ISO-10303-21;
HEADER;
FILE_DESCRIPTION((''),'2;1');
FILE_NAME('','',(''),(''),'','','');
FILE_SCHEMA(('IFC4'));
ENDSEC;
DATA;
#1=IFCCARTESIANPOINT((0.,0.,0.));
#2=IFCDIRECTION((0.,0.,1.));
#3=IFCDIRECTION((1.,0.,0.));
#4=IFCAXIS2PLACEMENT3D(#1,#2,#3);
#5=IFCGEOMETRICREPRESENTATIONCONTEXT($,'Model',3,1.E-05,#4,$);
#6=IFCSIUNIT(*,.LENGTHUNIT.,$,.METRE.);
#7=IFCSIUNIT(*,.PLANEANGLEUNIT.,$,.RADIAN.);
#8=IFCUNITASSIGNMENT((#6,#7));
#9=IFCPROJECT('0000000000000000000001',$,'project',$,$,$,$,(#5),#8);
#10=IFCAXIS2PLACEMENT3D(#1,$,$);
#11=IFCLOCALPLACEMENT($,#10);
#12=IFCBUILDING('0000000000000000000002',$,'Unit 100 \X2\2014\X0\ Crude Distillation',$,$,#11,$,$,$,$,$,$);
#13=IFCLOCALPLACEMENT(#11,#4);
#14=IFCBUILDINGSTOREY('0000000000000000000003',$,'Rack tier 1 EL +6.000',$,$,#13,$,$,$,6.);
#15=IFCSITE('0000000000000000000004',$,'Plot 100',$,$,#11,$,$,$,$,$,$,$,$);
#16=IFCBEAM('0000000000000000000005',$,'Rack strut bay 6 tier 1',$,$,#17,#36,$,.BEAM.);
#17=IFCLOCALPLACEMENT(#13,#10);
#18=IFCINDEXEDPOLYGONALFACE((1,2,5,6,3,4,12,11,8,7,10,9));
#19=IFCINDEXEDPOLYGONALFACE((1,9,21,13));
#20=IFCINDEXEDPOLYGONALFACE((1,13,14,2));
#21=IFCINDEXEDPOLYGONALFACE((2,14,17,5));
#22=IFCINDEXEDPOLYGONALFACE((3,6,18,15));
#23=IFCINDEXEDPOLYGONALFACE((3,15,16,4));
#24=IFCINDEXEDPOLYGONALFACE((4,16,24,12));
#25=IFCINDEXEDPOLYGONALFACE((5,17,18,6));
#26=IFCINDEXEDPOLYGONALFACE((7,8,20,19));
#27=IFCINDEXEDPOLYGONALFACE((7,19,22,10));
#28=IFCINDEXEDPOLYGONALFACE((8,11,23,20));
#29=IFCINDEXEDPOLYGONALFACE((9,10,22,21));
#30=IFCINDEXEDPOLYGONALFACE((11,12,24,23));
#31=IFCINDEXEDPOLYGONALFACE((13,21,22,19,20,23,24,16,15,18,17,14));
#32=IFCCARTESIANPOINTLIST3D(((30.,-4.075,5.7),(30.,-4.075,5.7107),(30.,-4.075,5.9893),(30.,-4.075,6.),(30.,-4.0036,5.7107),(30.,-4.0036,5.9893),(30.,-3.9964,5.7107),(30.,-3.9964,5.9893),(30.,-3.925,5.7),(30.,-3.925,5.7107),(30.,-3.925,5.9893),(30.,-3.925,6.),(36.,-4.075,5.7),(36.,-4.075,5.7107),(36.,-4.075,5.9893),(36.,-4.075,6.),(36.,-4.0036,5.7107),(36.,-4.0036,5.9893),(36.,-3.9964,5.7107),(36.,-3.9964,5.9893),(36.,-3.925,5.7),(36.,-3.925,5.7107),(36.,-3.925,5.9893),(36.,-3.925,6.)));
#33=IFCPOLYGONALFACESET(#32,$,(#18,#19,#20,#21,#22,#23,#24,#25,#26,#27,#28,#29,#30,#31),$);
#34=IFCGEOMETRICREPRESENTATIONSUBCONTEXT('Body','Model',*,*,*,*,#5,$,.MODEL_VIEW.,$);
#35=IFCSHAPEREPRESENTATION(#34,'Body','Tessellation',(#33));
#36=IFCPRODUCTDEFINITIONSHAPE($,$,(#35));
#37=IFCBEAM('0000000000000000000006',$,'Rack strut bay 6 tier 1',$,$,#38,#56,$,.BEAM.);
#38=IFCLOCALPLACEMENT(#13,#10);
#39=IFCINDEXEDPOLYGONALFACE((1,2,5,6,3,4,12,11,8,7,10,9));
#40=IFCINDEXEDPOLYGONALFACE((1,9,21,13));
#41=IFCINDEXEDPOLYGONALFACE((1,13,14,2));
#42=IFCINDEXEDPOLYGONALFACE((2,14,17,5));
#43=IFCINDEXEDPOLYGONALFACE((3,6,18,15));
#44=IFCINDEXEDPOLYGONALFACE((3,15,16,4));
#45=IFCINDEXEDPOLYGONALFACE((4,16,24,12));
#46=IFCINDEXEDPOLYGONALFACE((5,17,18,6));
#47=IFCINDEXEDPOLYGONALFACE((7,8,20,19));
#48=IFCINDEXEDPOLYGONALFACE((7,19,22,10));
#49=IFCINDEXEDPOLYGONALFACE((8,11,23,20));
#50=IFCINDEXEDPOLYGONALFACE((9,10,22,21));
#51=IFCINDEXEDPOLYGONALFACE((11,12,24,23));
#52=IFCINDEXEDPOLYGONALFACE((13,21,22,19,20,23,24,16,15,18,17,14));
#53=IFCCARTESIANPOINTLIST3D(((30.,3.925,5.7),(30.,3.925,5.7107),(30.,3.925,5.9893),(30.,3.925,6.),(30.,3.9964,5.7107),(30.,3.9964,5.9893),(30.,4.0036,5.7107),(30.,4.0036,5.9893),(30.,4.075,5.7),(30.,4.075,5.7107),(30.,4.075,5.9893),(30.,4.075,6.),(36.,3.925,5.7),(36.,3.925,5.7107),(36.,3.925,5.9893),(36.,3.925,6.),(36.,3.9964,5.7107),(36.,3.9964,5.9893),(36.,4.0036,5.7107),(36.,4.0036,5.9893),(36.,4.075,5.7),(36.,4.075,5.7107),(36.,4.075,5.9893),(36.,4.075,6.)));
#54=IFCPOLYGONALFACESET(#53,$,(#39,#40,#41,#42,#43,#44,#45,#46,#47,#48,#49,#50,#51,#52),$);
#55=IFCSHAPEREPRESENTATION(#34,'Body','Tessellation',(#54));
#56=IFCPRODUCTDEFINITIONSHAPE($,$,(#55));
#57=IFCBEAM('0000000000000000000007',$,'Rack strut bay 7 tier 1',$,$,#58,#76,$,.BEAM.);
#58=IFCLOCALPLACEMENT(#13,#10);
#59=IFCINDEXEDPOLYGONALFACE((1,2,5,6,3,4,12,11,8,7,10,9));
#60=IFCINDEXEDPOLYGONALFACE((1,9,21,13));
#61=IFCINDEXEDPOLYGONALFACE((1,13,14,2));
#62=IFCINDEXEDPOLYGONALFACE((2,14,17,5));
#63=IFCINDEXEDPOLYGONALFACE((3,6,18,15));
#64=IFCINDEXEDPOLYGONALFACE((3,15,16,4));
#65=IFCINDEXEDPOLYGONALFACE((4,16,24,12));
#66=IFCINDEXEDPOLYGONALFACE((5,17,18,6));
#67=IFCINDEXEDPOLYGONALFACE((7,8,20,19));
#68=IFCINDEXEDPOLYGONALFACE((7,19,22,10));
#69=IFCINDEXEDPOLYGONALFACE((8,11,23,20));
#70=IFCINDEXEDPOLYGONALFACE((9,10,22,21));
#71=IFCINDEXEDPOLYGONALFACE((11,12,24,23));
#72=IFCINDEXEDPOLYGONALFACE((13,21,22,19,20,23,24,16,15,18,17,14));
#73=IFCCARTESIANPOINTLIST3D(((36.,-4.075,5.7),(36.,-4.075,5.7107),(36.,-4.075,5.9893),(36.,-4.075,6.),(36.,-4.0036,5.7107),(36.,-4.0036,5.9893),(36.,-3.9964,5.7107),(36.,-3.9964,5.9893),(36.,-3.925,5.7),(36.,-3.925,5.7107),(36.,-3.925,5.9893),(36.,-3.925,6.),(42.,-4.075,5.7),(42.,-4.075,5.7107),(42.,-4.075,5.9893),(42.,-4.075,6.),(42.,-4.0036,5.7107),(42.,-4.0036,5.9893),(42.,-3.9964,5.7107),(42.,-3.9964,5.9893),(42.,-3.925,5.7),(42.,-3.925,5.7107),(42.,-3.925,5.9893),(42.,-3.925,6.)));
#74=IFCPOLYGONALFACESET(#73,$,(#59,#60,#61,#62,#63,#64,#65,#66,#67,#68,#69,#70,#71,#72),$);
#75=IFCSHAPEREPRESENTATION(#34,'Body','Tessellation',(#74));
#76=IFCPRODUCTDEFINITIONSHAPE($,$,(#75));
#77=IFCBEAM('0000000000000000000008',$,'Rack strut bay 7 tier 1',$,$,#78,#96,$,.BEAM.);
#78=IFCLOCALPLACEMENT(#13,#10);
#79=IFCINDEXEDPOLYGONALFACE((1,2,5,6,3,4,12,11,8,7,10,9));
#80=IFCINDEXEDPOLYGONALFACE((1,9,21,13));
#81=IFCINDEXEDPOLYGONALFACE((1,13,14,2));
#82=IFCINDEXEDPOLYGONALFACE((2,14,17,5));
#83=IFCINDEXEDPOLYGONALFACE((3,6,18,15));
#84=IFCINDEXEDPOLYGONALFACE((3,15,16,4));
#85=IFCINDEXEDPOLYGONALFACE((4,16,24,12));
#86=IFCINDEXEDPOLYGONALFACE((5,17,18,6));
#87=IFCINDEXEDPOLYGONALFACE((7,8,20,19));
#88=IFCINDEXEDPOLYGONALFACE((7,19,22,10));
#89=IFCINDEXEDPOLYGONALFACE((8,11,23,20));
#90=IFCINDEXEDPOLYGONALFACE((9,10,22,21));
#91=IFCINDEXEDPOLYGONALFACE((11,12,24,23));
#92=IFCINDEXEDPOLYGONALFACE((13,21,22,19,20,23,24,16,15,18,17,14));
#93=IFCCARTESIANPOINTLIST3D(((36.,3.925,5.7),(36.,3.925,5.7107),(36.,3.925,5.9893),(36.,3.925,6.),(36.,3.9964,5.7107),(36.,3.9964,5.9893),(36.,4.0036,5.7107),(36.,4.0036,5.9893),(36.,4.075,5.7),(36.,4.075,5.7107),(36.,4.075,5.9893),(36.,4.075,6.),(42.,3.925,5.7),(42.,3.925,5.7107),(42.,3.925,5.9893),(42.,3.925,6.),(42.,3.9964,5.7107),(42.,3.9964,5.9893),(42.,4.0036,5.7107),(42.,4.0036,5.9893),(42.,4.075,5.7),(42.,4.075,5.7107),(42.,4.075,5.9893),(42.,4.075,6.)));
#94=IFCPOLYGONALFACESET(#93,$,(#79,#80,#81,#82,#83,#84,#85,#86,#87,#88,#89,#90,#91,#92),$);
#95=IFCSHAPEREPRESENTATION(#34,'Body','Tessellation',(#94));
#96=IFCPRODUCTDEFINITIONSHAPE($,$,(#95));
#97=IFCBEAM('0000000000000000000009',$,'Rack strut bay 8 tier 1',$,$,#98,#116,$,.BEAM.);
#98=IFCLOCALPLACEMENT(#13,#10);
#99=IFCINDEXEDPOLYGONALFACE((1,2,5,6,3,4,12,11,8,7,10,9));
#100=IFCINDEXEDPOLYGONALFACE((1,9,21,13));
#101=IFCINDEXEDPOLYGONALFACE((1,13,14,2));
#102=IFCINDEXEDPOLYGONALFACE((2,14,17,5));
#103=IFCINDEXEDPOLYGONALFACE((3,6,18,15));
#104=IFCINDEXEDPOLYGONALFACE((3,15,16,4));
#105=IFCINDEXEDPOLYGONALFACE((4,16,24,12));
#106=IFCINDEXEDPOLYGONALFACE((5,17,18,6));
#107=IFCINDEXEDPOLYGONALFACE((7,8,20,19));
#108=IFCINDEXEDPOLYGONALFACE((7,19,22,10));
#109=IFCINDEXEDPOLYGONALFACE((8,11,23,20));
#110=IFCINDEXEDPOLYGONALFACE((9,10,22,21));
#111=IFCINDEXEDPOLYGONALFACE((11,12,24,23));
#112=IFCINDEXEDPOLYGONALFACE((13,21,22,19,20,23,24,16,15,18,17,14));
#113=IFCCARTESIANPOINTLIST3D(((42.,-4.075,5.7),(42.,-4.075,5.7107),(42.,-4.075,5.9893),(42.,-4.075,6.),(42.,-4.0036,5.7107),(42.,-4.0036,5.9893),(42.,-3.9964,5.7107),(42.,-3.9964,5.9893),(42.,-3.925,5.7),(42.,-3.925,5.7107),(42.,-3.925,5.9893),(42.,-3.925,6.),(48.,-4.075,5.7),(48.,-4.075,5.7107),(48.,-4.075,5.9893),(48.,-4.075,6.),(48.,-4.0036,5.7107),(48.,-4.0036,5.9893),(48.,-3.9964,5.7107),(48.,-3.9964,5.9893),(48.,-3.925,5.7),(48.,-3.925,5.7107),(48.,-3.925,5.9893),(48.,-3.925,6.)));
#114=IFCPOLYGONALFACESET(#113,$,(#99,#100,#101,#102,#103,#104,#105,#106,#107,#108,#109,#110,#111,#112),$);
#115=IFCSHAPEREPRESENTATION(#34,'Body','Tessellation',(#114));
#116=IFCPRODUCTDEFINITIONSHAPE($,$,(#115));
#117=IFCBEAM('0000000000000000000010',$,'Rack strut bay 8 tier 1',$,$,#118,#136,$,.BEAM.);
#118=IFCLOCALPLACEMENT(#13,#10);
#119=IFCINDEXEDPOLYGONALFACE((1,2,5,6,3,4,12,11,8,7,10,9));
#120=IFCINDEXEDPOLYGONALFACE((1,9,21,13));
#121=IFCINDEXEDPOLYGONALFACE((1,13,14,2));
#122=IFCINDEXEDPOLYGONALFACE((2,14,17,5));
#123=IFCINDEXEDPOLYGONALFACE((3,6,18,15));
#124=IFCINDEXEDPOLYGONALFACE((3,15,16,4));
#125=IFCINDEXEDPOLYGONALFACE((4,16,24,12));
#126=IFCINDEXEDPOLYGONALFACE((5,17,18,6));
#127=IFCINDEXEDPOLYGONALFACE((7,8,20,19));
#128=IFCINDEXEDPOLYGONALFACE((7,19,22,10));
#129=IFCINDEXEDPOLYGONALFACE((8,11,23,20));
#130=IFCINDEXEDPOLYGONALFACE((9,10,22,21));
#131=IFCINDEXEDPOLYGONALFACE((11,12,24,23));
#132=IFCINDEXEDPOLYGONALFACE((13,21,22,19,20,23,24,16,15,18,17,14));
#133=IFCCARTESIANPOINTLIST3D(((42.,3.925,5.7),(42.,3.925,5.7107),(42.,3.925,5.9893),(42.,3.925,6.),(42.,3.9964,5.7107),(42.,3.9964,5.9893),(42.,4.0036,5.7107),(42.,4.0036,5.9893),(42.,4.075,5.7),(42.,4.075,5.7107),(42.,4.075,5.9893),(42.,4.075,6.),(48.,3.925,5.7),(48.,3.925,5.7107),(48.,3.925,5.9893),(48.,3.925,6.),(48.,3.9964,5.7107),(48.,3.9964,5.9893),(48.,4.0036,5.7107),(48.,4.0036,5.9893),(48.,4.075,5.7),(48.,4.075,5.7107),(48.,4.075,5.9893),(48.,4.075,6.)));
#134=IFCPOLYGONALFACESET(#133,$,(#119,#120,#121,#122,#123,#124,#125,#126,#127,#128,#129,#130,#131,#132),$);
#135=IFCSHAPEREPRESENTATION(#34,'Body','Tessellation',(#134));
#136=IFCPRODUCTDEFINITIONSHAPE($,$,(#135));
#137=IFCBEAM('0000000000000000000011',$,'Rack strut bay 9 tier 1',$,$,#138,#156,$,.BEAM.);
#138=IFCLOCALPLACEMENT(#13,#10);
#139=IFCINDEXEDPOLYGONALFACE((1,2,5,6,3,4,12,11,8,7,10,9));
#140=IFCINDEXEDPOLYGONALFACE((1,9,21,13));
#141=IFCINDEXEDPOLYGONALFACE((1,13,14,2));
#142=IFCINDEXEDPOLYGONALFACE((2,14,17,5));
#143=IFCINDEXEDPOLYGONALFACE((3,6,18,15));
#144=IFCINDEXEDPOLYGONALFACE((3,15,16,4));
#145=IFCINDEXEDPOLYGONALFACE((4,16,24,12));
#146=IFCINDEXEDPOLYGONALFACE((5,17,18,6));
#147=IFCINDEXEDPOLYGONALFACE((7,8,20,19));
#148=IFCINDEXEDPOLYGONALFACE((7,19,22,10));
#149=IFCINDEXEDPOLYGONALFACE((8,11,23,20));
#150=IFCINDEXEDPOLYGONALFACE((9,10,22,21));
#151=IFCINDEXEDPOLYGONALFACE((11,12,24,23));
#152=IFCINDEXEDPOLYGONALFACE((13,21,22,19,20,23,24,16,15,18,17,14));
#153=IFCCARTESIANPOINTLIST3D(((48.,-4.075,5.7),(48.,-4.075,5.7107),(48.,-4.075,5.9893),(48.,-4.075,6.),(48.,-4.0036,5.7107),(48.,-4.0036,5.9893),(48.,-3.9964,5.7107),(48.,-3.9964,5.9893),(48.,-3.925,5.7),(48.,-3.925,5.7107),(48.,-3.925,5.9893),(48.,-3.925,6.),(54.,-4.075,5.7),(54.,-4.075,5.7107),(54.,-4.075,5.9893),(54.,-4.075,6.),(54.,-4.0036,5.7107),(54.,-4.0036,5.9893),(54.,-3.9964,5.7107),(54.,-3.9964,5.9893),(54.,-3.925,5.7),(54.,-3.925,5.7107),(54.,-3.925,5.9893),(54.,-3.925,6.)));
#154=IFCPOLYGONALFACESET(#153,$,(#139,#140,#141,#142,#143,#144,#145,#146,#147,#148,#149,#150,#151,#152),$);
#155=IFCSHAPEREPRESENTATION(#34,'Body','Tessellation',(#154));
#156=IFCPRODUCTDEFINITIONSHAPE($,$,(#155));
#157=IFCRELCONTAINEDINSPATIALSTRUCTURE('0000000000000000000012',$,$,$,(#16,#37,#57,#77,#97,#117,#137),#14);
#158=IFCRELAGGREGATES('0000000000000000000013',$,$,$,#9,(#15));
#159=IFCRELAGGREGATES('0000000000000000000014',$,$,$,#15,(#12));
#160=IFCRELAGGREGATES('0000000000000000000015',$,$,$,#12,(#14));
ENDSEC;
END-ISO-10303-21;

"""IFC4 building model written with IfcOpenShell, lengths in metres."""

from ifc_helpers import new_model, si_unit, frame, origin, origin_with_axes, origin_2d, place, context, subcontext, project, spatial, i_section, extrude, element, save


model = new_model("IFC4")

# Units and contexts
model_context = context("Model", 3, precision=1e-05, world=origin_with_axes())
body_context = subcontext(model_context, "Body", "Model", "MODEL_VIEW")
ifc_project = project(units=[si_unit("LENGTHUNIT", "METRE"), si_unit("PLANEANGLEUNIT", "RADIAN")], contexts=[model_context])

# Site, building, storey
placement = place(None, origin())
site = spatial("IfcSite", under=ifc_project, at=placement, Name="Plot 100")
building = spatial("IfcBuilding", under=site, at=placement, Name="Unit 100 — Crude Distillation")
storey_placement = place(placement, origin_with_axes())
storey = spatial("IfcBuildingStorey", under=building, at=storey_placement, Name="Rack tier 1 EL +6.000", Elevation=6.0)

# Beams
beam_1_placement = place(storey_placement, origin_with_axes())
element("IfcBeam", 1, at=beam_1_placement, inside=storey, Name="Rack strut bay 6 tier 1", PredefinedType="BEAM", context=body_context, shape_type="SweptSolid", body=[
    extrude(i_section(OverallWidth=0.15, OverallDepth=0.3, WebThickness=0.0071, FlangeThickness=0.0107, at=origin_2d()), frame((30.0, -4.0, 5.85), z_axis=(1.0, 0.0, 0.0), x_axis=(0.0, 1.0, 0.0)), (0.0, 0.0, 1.0), 6.0),
])
beam_2_placement = place(storey_placement, origin_with_axes())
element("IfcBeam", 2, at=beam_2_placement, inside=storey, Name="Rack strut bay 6 tier 1", PredefinedType="BEAM", context=body_context, shape_type="SweptSolid", body=[
    extrude(i_section(OverallWidth=0.15, OverallDepth=0.3, WebThickness=0.0071, FlangeThickness=0.0107, at=origin_2d()), frame((30.0, 4.0, 5.85), z_axis=(1.0, 0.0, 0.0), x_axis=(0.0, 1.0, 0.0)), (0.0, 0.0, 1.0), 6.0),
])
beam_3_placement = place(storey_placement, origin_with_axes())
element("IfcBeam", 3, at=beam_3_placement, inside=storey, Name="Rack strut bay 7 tier 1", PredefinedType="BEAM", context=body_context, shape_type="SweptSolid", body=[
    extrude(i_section(OverallWidth=0.15, OverallDepth=0.3, WebThickness=0.0071, FlangeThickness=0.0107, at=origin_2d()), frame((36.0, -4.0, 5.85), z_axis=(1.0, 0.0, 0.0), x_axis=(0.0, 1.0, 0.0)), (0.0, 0.0, 1.0), 6.0),
])
beam_4_placement = place(storey_placement, origin_with_axes())
element("IfcBeam", 4, at=beam_4_placement, inside=storey, Name="Rack strut bay 7 tier 1", PredefinedType="BEAM", context=body_context, shape_type="SweptSolid", body=[
    extrude(i_section(OverallWidth=0.15, OverallDepth=0.3, WebThickness=0.0071, FlangeThickness=0.0107, at=origin_2d()), frame((36.0, 4.0, 5.85), z_axis=(1.0, 0.0, 0.0), x_axis=(0.0, 1.0, 0.0)), (0.0, 0.0, 1.0), 6.0),
])
beam_5_placement = place(storey_placement, origin_with_axes())
element("IfcBeam", 5, at=beam_5_placement, inside=storey, Name="Rack strut bay 8 tier 1", PredefinedType="BEAM", context=body_context, shape_type="SweptSolid", body=[
    extrude(i_section(OverallWidth=0.15, OverallDepth=0.3, WebThickness=0.0071, FlangeThickness=0.0107, at=origin_2d()), frame((42.0, -4.0, 5.85), z_axis=(1.0, 0.0, 0.0), x_axis=(0.0, 1.0, 0.0)), (0.0, 0.0, 1.0), 6.0),
])
beam_6_placement = place(storey_placement, origin_with_axes())
element("IfcBeam", 6, at=beam_6_placement, inside=storey, Name="Rack strut bay 8 tier 1", PredefinedType="BEAM", context=body_context, shape_type="SweptSolid", body=[
    extrude(i_section(OverallWidth=0.15, OverallDepth=0.3, WebThickness=0.0071, FlangeThickness=0.0107, at=origin_2d()), frame((42.0, 4.0, 5.85), z_axis=(1.0, 0.0, 0.0), x_axis=(0.0, 1.0, 0.0)), (0.0, 0.0, 1.0), 6.0),
])
beam_7_placement = place(storey_placement, origin_with_axes())
element("IfcBeam", 7, at=beam_7_placement, inside=storey, Name="Rack strut bay 9 tier 1", PredefinedType="BEAM", context=body_context, shape_type="SweptSolid", body=[
    extrude(i_section(OverallWidth=0.15, OverallDepth=0.3, WebThickness=0.0071, FlangeThickness=0.0107, at=origin_2d()), frame((48.0, -4.0, 5.85), z_axis=(1.0, 0.0, 0.0), x_axis=(0.0, 1.0, 0.0)), (0.0, 0.0, 1.0), 6.0),
])

save(model, "model.ifc")
